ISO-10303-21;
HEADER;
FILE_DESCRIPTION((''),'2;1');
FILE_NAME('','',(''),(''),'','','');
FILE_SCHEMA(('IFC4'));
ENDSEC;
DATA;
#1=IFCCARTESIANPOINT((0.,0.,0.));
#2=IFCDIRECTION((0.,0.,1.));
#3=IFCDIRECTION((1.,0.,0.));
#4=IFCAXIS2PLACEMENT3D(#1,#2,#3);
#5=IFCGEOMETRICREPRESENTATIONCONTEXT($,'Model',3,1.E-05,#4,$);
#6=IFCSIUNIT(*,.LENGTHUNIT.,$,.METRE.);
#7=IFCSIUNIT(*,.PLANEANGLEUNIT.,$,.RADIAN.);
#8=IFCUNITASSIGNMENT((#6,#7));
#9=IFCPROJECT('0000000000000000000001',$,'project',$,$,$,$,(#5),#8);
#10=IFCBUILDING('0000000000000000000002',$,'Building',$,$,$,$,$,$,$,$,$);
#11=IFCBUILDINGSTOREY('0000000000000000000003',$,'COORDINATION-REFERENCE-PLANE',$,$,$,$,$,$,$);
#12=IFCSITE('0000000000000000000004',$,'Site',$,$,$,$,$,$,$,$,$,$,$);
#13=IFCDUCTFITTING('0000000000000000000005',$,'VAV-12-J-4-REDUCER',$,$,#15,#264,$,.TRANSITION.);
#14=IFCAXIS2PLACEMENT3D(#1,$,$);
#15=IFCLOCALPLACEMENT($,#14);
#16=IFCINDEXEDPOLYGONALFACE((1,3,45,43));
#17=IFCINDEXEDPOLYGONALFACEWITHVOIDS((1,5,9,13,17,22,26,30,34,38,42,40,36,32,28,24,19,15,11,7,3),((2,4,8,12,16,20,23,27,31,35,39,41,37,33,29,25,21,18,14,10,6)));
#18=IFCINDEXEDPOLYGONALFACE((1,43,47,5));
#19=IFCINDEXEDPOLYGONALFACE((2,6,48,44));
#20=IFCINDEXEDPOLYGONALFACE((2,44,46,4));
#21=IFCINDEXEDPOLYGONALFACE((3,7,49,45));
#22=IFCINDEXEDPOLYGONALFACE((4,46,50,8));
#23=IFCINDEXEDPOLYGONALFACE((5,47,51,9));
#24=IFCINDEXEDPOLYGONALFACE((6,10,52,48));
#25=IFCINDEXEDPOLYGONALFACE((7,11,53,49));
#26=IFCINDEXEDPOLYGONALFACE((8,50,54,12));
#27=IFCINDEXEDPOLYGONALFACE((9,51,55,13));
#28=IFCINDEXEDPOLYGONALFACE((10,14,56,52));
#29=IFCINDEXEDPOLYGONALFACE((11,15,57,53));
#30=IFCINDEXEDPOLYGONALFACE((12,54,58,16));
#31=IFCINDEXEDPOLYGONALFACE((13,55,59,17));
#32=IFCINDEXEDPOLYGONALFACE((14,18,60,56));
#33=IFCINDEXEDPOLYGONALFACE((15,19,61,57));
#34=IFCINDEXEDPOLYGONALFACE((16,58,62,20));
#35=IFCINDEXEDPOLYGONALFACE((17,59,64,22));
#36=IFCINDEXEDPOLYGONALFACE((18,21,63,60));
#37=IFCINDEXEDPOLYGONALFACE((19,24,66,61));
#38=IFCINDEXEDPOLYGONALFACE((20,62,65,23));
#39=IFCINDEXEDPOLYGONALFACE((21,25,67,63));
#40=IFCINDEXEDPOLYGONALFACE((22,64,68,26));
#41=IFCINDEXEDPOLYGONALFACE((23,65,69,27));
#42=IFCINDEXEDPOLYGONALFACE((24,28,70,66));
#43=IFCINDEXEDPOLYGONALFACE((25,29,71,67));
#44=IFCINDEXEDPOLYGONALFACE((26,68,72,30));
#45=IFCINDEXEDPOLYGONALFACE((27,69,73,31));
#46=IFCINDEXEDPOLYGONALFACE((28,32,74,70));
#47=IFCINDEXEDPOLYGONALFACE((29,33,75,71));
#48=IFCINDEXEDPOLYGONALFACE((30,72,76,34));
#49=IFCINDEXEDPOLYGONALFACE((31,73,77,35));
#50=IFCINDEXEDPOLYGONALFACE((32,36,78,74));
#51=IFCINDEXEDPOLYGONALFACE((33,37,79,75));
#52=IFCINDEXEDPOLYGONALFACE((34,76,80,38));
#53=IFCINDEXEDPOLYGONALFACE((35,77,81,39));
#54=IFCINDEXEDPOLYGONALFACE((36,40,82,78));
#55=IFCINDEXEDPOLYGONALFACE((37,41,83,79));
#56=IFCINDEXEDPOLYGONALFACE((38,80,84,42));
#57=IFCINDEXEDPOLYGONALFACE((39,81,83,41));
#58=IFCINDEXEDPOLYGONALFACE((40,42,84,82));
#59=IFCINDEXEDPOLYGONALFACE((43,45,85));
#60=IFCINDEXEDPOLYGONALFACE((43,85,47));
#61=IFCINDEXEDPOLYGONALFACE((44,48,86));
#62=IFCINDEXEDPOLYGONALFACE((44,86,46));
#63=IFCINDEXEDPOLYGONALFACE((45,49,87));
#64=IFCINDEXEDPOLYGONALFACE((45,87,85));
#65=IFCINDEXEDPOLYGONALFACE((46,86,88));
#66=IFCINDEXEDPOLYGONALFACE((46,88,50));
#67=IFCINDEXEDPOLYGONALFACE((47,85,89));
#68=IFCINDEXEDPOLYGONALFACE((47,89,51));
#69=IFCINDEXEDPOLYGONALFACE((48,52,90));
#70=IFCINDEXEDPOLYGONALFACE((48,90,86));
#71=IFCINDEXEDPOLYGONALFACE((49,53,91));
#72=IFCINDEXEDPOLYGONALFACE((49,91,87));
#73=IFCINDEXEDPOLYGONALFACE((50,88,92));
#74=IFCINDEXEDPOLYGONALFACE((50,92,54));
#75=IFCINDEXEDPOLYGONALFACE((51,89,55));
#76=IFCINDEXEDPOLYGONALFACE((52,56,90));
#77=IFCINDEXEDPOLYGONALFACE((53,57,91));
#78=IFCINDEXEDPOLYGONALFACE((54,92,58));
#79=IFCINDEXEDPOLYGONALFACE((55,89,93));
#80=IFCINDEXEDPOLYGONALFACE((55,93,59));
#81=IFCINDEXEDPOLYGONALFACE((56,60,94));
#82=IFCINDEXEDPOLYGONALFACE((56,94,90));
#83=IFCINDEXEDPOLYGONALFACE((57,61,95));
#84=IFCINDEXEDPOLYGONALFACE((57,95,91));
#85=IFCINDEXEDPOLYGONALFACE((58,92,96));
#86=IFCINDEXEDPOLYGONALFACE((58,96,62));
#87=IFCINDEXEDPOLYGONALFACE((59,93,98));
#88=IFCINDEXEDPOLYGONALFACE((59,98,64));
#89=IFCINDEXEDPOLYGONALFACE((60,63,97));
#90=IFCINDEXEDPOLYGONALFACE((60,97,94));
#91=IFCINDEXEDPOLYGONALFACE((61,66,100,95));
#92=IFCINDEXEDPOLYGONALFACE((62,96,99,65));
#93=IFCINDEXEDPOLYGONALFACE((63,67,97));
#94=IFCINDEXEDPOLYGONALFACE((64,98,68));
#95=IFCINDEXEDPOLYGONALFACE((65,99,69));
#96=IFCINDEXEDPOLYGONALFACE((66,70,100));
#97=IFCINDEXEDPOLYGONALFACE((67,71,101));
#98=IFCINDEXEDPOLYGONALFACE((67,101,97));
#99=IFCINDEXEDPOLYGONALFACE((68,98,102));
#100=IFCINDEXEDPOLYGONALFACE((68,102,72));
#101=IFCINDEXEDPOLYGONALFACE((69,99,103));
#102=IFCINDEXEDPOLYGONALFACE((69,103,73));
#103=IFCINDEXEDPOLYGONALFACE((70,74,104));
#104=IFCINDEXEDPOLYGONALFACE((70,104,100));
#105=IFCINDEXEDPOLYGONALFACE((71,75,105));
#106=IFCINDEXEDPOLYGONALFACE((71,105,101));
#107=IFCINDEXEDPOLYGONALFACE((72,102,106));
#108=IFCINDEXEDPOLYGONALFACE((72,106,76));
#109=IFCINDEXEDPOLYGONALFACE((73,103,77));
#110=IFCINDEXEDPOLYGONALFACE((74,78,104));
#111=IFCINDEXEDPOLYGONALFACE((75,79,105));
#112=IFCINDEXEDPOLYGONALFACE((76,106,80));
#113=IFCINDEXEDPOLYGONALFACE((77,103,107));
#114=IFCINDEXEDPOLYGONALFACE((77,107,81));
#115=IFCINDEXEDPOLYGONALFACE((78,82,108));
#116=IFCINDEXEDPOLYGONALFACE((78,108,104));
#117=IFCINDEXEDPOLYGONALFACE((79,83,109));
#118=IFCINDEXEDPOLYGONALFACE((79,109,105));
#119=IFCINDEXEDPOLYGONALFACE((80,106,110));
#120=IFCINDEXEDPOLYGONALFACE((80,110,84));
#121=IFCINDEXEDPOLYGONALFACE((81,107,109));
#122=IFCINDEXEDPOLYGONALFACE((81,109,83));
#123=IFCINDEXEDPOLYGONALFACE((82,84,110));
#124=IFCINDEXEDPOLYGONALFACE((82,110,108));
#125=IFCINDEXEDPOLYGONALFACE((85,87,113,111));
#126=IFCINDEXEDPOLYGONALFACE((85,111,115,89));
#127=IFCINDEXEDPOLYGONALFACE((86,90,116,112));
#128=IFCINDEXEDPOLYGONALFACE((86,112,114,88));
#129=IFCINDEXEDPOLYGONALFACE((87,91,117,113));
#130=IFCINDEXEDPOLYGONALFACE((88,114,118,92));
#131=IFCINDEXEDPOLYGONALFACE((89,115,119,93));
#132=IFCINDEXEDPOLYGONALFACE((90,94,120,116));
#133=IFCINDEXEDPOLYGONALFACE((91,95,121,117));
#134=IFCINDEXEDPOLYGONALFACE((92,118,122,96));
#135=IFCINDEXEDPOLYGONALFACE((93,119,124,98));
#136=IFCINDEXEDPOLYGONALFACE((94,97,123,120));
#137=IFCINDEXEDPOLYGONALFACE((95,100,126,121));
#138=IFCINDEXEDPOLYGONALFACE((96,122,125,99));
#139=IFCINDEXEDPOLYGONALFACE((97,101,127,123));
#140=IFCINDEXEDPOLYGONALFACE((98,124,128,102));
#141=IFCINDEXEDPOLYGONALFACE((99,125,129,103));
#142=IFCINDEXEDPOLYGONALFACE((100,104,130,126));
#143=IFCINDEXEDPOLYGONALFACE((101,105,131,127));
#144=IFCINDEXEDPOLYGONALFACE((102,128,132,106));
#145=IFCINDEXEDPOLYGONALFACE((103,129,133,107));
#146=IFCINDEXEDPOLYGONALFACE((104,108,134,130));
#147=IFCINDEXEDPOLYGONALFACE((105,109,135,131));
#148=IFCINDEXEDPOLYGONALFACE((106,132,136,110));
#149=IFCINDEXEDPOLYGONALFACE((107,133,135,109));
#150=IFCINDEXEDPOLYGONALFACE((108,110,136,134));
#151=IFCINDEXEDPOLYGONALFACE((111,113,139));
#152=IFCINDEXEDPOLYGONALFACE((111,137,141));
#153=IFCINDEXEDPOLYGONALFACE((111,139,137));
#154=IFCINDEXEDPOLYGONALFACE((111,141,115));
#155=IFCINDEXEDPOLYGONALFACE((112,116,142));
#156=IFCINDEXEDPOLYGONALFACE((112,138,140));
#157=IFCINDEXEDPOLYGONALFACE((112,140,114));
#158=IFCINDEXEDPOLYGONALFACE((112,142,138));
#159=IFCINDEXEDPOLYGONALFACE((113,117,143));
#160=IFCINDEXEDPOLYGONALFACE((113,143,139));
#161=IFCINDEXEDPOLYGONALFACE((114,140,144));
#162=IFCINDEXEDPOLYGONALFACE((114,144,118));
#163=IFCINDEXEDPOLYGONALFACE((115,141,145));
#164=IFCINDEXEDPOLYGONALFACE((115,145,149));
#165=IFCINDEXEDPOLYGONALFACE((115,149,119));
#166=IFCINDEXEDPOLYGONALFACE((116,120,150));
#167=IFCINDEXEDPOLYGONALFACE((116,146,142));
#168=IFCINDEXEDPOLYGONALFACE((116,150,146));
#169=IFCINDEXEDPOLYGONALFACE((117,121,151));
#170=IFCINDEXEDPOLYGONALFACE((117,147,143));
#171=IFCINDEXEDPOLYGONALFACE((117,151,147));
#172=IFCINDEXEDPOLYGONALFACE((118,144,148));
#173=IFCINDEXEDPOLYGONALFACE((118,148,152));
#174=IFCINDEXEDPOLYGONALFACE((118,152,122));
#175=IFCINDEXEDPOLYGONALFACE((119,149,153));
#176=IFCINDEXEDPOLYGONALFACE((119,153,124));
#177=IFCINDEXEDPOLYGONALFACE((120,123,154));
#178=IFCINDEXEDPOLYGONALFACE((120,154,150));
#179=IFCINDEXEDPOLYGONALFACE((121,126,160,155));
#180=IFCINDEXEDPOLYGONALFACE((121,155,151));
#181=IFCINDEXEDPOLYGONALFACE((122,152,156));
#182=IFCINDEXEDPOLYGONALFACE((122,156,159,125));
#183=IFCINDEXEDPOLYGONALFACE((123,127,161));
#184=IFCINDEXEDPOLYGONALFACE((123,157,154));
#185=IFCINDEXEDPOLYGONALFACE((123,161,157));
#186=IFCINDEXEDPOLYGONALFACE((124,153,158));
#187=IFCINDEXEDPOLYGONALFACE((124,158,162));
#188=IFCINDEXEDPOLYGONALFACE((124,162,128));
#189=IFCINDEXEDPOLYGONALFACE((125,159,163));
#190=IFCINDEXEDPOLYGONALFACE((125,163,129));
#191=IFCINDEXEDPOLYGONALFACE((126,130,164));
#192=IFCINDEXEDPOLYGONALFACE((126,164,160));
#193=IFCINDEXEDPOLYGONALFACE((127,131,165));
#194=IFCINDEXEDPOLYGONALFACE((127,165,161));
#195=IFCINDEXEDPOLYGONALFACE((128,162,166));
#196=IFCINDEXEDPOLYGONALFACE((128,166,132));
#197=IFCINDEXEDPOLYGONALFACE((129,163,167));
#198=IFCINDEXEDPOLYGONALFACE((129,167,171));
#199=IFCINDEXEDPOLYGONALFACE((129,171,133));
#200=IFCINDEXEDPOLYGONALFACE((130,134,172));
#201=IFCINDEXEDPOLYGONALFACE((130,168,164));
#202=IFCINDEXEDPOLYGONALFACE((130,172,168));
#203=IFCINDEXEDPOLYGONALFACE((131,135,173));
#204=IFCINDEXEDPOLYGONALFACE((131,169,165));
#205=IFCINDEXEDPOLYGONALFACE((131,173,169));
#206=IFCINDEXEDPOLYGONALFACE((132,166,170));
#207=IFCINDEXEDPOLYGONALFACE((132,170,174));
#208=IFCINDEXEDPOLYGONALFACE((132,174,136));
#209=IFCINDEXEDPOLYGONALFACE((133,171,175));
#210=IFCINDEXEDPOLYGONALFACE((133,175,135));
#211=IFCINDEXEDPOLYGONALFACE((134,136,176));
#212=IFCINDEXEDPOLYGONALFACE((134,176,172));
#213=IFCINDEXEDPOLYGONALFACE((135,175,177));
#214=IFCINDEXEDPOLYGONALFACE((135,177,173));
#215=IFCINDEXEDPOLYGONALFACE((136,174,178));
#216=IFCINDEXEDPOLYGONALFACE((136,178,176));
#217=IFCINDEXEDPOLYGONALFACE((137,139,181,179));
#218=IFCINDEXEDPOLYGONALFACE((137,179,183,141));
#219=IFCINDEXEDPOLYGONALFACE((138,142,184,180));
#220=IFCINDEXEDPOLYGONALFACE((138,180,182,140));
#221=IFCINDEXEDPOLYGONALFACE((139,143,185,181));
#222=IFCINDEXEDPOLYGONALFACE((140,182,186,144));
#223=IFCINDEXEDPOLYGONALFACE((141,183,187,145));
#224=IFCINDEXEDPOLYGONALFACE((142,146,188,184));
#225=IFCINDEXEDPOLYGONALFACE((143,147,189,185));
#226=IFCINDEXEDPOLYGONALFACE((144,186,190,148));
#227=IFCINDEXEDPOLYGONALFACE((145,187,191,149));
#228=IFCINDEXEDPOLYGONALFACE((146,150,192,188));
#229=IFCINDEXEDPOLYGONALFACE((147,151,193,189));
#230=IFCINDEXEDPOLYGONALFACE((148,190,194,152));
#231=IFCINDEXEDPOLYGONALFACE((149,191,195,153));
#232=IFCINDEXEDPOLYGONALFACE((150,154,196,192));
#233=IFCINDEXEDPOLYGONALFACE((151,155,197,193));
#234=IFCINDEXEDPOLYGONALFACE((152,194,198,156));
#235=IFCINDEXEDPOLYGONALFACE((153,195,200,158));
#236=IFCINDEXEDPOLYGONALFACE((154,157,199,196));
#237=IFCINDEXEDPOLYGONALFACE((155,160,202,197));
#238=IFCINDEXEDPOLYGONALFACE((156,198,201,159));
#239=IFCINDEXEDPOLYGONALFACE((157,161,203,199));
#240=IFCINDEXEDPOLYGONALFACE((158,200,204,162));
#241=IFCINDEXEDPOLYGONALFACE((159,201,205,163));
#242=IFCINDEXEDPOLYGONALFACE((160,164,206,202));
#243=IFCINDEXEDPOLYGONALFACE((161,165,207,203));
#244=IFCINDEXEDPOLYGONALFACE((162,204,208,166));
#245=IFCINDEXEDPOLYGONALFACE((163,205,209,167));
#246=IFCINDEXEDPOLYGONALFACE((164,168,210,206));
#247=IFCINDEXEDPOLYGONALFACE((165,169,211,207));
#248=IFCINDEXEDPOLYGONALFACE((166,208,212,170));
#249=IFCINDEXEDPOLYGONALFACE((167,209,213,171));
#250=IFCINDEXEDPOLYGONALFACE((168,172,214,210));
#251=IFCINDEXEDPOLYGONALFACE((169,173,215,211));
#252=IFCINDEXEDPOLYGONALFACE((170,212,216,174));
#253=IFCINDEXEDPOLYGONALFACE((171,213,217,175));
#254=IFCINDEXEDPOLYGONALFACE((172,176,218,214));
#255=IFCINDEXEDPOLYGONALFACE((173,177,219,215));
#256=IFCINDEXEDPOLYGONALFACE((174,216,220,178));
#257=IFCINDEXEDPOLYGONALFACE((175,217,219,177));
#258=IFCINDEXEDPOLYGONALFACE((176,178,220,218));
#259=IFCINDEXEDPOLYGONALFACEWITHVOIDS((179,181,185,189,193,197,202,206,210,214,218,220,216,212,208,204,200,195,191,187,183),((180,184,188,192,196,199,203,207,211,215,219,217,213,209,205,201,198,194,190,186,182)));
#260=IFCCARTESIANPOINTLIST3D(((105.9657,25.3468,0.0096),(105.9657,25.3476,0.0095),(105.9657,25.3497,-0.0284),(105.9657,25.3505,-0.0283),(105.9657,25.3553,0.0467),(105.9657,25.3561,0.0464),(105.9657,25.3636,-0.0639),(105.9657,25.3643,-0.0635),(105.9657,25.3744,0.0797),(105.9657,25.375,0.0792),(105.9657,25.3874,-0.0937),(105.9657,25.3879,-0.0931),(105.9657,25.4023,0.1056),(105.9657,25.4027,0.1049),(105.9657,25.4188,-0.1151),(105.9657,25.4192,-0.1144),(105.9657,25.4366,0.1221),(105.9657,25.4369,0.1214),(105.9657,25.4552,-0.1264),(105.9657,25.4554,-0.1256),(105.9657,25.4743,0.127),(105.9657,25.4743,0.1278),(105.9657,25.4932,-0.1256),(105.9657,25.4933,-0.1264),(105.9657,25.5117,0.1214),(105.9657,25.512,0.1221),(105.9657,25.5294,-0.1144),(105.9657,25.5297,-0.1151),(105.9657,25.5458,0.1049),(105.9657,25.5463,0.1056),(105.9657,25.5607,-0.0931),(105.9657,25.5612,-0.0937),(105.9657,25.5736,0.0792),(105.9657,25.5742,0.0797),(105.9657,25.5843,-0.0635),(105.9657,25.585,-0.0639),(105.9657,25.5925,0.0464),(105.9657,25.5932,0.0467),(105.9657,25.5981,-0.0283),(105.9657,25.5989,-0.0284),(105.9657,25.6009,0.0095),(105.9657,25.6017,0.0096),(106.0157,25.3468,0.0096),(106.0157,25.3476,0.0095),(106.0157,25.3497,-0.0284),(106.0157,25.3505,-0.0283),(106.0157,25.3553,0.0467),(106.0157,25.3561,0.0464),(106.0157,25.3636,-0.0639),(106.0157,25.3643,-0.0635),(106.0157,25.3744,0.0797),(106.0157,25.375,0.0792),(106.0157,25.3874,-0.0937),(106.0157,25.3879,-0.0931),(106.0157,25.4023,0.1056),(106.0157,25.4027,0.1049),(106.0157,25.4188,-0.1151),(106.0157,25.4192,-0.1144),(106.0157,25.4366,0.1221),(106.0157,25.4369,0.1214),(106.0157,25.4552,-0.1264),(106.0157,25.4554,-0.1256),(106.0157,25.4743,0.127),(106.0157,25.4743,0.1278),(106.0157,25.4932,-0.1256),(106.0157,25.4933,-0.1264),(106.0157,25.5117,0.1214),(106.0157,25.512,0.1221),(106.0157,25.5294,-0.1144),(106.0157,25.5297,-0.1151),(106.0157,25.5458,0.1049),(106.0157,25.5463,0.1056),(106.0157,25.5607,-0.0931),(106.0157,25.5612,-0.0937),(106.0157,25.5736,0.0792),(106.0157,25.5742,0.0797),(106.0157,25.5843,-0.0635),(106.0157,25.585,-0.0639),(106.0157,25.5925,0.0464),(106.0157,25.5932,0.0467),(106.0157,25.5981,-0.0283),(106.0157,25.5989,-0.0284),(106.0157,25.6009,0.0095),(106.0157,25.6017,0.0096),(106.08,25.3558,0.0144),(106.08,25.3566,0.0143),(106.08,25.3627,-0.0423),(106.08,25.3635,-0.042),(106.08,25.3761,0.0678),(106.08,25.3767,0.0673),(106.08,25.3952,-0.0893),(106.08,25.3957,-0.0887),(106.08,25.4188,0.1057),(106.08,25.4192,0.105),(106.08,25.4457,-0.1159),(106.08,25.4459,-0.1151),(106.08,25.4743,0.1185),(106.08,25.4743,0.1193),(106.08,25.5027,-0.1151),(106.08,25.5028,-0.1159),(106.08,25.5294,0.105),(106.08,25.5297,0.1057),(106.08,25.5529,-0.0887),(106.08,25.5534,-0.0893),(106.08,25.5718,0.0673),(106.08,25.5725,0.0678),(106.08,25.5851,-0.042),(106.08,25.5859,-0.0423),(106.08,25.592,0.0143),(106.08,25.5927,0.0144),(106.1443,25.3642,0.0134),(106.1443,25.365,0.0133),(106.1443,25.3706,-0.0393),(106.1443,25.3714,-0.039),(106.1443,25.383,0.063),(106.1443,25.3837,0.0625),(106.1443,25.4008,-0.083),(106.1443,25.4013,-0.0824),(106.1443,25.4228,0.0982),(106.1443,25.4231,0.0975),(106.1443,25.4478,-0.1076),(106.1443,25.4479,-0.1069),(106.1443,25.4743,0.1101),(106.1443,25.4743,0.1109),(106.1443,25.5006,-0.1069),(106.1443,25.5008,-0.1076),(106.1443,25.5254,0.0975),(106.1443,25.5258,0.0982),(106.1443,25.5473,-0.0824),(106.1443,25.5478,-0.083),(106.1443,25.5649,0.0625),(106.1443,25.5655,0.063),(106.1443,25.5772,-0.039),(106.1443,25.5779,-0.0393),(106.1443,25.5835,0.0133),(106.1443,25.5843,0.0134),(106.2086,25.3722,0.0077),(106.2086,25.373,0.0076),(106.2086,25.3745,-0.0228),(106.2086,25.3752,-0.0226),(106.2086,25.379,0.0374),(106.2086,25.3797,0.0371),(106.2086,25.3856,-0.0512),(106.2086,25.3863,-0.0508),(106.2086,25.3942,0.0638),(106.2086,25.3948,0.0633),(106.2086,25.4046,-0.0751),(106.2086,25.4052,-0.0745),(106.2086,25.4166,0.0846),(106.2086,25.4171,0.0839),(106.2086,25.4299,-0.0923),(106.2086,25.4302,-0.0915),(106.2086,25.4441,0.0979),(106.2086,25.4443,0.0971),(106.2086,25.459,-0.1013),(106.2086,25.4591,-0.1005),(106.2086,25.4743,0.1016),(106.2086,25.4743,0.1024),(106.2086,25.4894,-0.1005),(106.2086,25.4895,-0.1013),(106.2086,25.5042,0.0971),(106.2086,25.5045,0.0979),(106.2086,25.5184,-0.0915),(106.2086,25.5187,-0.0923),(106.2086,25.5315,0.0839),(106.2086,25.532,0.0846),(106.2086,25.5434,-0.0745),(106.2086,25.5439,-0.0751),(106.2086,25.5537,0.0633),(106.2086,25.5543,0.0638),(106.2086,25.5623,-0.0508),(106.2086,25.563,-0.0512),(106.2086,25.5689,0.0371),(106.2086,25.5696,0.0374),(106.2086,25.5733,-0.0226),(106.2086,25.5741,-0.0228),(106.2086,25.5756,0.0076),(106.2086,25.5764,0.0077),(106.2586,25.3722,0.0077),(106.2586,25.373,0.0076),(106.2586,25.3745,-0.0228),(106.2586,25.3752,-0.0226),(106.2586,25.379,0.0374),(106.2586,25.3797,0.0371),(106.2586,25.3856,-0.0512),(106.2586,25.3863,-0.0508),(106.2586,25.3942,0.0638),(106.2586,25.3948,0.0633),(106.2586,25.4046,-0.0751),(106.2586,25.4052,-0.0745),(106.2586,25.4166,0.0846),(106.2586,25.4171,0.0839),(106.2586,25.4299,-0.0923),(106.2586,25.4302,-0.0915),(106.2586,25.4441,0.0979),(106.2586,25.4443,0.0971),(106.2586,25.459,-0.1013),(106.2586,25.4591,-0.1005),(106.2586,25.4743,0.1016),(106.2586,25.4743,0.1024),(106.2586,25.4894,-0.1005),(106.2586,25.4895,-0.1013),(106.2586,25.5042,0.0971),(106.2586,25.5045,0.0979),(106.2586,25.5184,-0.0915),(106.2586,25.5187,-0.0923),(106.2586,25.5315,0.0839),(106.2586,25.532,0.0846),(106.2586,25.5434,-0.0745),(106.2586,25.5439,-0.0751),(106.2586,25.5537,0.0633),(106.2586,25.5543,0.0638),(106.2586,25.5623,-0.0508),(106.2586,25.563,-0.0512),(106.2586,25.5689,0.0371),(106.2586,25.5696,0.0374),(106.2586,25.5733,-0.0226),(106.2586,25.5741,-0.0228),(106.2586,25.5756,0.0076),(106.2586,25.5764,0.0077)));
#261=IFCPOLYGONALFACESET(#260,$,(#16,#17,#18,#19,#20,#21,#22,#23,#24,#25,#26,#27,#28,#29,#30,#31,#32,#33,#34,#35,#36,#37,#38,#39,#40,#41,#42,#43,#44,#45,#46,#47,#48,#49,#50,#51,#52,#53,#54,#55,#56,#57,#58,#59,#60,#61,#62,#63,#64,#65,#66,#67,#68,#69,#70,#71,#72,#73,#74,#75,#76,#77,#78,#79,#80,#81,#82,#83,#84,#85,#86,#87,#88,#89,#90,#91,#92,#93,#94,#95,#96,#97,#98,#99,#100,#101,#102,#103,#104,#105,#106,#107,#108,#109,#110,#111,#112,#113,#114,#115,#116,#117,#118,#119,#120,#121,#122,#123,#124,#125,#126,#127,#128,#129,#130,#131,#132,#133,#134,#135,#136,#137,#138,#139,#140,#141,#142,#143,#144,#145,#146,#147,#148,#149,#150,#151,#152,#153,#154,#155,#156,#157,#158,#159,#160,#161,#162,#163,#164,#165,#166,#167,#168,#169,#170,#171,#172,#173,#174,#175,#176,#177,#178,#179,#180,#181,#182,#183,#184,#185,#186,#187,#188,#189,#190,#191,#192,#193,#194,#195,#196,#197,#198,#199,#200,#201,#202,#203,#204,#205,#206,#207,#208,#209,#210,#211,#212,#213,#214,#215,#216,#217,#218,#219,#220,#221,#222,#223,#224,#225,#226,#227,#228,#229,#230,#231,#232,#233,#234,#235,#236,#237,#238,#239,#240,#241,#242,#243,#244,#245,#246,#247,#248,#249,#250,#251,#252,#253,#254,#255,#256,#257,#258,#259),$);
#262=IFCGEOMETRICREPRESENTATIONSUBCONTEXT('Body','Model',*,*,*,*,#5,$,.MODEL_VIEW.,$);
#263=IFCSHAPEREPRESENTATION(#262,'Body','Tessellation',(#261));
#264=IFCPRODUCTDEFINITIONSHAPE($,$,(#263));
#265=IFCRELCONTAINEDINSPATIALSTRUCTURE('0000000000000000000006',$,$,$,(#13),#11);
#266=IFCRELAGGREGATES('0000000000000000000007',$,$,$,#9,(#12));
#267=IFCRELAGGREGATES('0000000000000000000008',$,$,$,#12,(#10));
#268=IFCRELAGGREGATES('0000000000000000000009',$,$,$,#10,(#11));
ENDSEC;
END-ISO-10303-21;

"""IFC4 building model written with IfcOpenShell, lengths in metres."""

from ifc_helpers import new_model, entity, si_unit, frame, origin_with_axes, place, context, subcontext, project, spatial, element, save


model = new_model("IFC4")

# Units and contexts
model_context = context("Model", 3, precision=1e-05, world=origin_with_axes())
body_context_1 = subcontext(model_context, "Body", "Model", "MODEL_VIEW")
ifc_project = project(units=[si_unit("LENGTHUNIT", "METRE"), si_unit("PLANEANGLEUNIT", "RADIAN")], contexts=[model_context])

# Site, building, storey
site = spatial("IfcSite", under=ifc_project, Name="Site")
building = spatial("IfcBuilding", under=site, Name="Building")
storey = spatial("IfcBuildingStorey", under=building, Name="COORDINATION-REFERENCE-PLANE")

# Duct fitting
for number, where, z_axis, x_axis, name in (
    (1, (105.9657, 25.4743, 0.0), (0.0, 1.0, 0.0), (0.0, 0.0, 1.0), "VAV-12-J-4-REDUCER"),
):
    element("IfcDuctFitting", number, at=place(None, frame(where, z_axis=z_axis, x_axis=x_axis)), inside=storey, Name=name, PredefinedType="TRANSITION", context=body_context_1, shape_type="SweptSolid", body=[
        entity("IfcRevolvedAreaSolid", entity("IfcArbitraryClosedProfileDef", "AREA", None, entity("IfcPolyline", [entity("IfcCartesianPoint", [0.1278, 0.0]), entity("IfcCartesianPoint", [0.1278, 0.05]), entity("IfcCartesianPoint", [0.1024, 0.2429]), entity("IfcCartesianPoint", [0.1024, 0.2929]), entity("IfcCartesianPoint", [0.1016, 0.2929]), entity("IfcCartesianPoint", [0.1016, 0.2429]), entity("IfcCartesianPoint", [0.127, 0.05]), entity("IfcCartesianPoint", [0.127, 0.0]), entity("IfcCartesianPoint", [0.1278, 0.0])])), entity("IfcAxis2Placement3D", entity("IfcCartesianPoint", [0.0, 0.0, 0.0])), entity("IfcAxis1Placement", entity("IfcCartesianPoint", [0.0, 0.0, 0.0]), entity("IfcDirection", [0.0, 1.0, 0.0])), 6.283185),
    ])

save(model, "model.ifc")
